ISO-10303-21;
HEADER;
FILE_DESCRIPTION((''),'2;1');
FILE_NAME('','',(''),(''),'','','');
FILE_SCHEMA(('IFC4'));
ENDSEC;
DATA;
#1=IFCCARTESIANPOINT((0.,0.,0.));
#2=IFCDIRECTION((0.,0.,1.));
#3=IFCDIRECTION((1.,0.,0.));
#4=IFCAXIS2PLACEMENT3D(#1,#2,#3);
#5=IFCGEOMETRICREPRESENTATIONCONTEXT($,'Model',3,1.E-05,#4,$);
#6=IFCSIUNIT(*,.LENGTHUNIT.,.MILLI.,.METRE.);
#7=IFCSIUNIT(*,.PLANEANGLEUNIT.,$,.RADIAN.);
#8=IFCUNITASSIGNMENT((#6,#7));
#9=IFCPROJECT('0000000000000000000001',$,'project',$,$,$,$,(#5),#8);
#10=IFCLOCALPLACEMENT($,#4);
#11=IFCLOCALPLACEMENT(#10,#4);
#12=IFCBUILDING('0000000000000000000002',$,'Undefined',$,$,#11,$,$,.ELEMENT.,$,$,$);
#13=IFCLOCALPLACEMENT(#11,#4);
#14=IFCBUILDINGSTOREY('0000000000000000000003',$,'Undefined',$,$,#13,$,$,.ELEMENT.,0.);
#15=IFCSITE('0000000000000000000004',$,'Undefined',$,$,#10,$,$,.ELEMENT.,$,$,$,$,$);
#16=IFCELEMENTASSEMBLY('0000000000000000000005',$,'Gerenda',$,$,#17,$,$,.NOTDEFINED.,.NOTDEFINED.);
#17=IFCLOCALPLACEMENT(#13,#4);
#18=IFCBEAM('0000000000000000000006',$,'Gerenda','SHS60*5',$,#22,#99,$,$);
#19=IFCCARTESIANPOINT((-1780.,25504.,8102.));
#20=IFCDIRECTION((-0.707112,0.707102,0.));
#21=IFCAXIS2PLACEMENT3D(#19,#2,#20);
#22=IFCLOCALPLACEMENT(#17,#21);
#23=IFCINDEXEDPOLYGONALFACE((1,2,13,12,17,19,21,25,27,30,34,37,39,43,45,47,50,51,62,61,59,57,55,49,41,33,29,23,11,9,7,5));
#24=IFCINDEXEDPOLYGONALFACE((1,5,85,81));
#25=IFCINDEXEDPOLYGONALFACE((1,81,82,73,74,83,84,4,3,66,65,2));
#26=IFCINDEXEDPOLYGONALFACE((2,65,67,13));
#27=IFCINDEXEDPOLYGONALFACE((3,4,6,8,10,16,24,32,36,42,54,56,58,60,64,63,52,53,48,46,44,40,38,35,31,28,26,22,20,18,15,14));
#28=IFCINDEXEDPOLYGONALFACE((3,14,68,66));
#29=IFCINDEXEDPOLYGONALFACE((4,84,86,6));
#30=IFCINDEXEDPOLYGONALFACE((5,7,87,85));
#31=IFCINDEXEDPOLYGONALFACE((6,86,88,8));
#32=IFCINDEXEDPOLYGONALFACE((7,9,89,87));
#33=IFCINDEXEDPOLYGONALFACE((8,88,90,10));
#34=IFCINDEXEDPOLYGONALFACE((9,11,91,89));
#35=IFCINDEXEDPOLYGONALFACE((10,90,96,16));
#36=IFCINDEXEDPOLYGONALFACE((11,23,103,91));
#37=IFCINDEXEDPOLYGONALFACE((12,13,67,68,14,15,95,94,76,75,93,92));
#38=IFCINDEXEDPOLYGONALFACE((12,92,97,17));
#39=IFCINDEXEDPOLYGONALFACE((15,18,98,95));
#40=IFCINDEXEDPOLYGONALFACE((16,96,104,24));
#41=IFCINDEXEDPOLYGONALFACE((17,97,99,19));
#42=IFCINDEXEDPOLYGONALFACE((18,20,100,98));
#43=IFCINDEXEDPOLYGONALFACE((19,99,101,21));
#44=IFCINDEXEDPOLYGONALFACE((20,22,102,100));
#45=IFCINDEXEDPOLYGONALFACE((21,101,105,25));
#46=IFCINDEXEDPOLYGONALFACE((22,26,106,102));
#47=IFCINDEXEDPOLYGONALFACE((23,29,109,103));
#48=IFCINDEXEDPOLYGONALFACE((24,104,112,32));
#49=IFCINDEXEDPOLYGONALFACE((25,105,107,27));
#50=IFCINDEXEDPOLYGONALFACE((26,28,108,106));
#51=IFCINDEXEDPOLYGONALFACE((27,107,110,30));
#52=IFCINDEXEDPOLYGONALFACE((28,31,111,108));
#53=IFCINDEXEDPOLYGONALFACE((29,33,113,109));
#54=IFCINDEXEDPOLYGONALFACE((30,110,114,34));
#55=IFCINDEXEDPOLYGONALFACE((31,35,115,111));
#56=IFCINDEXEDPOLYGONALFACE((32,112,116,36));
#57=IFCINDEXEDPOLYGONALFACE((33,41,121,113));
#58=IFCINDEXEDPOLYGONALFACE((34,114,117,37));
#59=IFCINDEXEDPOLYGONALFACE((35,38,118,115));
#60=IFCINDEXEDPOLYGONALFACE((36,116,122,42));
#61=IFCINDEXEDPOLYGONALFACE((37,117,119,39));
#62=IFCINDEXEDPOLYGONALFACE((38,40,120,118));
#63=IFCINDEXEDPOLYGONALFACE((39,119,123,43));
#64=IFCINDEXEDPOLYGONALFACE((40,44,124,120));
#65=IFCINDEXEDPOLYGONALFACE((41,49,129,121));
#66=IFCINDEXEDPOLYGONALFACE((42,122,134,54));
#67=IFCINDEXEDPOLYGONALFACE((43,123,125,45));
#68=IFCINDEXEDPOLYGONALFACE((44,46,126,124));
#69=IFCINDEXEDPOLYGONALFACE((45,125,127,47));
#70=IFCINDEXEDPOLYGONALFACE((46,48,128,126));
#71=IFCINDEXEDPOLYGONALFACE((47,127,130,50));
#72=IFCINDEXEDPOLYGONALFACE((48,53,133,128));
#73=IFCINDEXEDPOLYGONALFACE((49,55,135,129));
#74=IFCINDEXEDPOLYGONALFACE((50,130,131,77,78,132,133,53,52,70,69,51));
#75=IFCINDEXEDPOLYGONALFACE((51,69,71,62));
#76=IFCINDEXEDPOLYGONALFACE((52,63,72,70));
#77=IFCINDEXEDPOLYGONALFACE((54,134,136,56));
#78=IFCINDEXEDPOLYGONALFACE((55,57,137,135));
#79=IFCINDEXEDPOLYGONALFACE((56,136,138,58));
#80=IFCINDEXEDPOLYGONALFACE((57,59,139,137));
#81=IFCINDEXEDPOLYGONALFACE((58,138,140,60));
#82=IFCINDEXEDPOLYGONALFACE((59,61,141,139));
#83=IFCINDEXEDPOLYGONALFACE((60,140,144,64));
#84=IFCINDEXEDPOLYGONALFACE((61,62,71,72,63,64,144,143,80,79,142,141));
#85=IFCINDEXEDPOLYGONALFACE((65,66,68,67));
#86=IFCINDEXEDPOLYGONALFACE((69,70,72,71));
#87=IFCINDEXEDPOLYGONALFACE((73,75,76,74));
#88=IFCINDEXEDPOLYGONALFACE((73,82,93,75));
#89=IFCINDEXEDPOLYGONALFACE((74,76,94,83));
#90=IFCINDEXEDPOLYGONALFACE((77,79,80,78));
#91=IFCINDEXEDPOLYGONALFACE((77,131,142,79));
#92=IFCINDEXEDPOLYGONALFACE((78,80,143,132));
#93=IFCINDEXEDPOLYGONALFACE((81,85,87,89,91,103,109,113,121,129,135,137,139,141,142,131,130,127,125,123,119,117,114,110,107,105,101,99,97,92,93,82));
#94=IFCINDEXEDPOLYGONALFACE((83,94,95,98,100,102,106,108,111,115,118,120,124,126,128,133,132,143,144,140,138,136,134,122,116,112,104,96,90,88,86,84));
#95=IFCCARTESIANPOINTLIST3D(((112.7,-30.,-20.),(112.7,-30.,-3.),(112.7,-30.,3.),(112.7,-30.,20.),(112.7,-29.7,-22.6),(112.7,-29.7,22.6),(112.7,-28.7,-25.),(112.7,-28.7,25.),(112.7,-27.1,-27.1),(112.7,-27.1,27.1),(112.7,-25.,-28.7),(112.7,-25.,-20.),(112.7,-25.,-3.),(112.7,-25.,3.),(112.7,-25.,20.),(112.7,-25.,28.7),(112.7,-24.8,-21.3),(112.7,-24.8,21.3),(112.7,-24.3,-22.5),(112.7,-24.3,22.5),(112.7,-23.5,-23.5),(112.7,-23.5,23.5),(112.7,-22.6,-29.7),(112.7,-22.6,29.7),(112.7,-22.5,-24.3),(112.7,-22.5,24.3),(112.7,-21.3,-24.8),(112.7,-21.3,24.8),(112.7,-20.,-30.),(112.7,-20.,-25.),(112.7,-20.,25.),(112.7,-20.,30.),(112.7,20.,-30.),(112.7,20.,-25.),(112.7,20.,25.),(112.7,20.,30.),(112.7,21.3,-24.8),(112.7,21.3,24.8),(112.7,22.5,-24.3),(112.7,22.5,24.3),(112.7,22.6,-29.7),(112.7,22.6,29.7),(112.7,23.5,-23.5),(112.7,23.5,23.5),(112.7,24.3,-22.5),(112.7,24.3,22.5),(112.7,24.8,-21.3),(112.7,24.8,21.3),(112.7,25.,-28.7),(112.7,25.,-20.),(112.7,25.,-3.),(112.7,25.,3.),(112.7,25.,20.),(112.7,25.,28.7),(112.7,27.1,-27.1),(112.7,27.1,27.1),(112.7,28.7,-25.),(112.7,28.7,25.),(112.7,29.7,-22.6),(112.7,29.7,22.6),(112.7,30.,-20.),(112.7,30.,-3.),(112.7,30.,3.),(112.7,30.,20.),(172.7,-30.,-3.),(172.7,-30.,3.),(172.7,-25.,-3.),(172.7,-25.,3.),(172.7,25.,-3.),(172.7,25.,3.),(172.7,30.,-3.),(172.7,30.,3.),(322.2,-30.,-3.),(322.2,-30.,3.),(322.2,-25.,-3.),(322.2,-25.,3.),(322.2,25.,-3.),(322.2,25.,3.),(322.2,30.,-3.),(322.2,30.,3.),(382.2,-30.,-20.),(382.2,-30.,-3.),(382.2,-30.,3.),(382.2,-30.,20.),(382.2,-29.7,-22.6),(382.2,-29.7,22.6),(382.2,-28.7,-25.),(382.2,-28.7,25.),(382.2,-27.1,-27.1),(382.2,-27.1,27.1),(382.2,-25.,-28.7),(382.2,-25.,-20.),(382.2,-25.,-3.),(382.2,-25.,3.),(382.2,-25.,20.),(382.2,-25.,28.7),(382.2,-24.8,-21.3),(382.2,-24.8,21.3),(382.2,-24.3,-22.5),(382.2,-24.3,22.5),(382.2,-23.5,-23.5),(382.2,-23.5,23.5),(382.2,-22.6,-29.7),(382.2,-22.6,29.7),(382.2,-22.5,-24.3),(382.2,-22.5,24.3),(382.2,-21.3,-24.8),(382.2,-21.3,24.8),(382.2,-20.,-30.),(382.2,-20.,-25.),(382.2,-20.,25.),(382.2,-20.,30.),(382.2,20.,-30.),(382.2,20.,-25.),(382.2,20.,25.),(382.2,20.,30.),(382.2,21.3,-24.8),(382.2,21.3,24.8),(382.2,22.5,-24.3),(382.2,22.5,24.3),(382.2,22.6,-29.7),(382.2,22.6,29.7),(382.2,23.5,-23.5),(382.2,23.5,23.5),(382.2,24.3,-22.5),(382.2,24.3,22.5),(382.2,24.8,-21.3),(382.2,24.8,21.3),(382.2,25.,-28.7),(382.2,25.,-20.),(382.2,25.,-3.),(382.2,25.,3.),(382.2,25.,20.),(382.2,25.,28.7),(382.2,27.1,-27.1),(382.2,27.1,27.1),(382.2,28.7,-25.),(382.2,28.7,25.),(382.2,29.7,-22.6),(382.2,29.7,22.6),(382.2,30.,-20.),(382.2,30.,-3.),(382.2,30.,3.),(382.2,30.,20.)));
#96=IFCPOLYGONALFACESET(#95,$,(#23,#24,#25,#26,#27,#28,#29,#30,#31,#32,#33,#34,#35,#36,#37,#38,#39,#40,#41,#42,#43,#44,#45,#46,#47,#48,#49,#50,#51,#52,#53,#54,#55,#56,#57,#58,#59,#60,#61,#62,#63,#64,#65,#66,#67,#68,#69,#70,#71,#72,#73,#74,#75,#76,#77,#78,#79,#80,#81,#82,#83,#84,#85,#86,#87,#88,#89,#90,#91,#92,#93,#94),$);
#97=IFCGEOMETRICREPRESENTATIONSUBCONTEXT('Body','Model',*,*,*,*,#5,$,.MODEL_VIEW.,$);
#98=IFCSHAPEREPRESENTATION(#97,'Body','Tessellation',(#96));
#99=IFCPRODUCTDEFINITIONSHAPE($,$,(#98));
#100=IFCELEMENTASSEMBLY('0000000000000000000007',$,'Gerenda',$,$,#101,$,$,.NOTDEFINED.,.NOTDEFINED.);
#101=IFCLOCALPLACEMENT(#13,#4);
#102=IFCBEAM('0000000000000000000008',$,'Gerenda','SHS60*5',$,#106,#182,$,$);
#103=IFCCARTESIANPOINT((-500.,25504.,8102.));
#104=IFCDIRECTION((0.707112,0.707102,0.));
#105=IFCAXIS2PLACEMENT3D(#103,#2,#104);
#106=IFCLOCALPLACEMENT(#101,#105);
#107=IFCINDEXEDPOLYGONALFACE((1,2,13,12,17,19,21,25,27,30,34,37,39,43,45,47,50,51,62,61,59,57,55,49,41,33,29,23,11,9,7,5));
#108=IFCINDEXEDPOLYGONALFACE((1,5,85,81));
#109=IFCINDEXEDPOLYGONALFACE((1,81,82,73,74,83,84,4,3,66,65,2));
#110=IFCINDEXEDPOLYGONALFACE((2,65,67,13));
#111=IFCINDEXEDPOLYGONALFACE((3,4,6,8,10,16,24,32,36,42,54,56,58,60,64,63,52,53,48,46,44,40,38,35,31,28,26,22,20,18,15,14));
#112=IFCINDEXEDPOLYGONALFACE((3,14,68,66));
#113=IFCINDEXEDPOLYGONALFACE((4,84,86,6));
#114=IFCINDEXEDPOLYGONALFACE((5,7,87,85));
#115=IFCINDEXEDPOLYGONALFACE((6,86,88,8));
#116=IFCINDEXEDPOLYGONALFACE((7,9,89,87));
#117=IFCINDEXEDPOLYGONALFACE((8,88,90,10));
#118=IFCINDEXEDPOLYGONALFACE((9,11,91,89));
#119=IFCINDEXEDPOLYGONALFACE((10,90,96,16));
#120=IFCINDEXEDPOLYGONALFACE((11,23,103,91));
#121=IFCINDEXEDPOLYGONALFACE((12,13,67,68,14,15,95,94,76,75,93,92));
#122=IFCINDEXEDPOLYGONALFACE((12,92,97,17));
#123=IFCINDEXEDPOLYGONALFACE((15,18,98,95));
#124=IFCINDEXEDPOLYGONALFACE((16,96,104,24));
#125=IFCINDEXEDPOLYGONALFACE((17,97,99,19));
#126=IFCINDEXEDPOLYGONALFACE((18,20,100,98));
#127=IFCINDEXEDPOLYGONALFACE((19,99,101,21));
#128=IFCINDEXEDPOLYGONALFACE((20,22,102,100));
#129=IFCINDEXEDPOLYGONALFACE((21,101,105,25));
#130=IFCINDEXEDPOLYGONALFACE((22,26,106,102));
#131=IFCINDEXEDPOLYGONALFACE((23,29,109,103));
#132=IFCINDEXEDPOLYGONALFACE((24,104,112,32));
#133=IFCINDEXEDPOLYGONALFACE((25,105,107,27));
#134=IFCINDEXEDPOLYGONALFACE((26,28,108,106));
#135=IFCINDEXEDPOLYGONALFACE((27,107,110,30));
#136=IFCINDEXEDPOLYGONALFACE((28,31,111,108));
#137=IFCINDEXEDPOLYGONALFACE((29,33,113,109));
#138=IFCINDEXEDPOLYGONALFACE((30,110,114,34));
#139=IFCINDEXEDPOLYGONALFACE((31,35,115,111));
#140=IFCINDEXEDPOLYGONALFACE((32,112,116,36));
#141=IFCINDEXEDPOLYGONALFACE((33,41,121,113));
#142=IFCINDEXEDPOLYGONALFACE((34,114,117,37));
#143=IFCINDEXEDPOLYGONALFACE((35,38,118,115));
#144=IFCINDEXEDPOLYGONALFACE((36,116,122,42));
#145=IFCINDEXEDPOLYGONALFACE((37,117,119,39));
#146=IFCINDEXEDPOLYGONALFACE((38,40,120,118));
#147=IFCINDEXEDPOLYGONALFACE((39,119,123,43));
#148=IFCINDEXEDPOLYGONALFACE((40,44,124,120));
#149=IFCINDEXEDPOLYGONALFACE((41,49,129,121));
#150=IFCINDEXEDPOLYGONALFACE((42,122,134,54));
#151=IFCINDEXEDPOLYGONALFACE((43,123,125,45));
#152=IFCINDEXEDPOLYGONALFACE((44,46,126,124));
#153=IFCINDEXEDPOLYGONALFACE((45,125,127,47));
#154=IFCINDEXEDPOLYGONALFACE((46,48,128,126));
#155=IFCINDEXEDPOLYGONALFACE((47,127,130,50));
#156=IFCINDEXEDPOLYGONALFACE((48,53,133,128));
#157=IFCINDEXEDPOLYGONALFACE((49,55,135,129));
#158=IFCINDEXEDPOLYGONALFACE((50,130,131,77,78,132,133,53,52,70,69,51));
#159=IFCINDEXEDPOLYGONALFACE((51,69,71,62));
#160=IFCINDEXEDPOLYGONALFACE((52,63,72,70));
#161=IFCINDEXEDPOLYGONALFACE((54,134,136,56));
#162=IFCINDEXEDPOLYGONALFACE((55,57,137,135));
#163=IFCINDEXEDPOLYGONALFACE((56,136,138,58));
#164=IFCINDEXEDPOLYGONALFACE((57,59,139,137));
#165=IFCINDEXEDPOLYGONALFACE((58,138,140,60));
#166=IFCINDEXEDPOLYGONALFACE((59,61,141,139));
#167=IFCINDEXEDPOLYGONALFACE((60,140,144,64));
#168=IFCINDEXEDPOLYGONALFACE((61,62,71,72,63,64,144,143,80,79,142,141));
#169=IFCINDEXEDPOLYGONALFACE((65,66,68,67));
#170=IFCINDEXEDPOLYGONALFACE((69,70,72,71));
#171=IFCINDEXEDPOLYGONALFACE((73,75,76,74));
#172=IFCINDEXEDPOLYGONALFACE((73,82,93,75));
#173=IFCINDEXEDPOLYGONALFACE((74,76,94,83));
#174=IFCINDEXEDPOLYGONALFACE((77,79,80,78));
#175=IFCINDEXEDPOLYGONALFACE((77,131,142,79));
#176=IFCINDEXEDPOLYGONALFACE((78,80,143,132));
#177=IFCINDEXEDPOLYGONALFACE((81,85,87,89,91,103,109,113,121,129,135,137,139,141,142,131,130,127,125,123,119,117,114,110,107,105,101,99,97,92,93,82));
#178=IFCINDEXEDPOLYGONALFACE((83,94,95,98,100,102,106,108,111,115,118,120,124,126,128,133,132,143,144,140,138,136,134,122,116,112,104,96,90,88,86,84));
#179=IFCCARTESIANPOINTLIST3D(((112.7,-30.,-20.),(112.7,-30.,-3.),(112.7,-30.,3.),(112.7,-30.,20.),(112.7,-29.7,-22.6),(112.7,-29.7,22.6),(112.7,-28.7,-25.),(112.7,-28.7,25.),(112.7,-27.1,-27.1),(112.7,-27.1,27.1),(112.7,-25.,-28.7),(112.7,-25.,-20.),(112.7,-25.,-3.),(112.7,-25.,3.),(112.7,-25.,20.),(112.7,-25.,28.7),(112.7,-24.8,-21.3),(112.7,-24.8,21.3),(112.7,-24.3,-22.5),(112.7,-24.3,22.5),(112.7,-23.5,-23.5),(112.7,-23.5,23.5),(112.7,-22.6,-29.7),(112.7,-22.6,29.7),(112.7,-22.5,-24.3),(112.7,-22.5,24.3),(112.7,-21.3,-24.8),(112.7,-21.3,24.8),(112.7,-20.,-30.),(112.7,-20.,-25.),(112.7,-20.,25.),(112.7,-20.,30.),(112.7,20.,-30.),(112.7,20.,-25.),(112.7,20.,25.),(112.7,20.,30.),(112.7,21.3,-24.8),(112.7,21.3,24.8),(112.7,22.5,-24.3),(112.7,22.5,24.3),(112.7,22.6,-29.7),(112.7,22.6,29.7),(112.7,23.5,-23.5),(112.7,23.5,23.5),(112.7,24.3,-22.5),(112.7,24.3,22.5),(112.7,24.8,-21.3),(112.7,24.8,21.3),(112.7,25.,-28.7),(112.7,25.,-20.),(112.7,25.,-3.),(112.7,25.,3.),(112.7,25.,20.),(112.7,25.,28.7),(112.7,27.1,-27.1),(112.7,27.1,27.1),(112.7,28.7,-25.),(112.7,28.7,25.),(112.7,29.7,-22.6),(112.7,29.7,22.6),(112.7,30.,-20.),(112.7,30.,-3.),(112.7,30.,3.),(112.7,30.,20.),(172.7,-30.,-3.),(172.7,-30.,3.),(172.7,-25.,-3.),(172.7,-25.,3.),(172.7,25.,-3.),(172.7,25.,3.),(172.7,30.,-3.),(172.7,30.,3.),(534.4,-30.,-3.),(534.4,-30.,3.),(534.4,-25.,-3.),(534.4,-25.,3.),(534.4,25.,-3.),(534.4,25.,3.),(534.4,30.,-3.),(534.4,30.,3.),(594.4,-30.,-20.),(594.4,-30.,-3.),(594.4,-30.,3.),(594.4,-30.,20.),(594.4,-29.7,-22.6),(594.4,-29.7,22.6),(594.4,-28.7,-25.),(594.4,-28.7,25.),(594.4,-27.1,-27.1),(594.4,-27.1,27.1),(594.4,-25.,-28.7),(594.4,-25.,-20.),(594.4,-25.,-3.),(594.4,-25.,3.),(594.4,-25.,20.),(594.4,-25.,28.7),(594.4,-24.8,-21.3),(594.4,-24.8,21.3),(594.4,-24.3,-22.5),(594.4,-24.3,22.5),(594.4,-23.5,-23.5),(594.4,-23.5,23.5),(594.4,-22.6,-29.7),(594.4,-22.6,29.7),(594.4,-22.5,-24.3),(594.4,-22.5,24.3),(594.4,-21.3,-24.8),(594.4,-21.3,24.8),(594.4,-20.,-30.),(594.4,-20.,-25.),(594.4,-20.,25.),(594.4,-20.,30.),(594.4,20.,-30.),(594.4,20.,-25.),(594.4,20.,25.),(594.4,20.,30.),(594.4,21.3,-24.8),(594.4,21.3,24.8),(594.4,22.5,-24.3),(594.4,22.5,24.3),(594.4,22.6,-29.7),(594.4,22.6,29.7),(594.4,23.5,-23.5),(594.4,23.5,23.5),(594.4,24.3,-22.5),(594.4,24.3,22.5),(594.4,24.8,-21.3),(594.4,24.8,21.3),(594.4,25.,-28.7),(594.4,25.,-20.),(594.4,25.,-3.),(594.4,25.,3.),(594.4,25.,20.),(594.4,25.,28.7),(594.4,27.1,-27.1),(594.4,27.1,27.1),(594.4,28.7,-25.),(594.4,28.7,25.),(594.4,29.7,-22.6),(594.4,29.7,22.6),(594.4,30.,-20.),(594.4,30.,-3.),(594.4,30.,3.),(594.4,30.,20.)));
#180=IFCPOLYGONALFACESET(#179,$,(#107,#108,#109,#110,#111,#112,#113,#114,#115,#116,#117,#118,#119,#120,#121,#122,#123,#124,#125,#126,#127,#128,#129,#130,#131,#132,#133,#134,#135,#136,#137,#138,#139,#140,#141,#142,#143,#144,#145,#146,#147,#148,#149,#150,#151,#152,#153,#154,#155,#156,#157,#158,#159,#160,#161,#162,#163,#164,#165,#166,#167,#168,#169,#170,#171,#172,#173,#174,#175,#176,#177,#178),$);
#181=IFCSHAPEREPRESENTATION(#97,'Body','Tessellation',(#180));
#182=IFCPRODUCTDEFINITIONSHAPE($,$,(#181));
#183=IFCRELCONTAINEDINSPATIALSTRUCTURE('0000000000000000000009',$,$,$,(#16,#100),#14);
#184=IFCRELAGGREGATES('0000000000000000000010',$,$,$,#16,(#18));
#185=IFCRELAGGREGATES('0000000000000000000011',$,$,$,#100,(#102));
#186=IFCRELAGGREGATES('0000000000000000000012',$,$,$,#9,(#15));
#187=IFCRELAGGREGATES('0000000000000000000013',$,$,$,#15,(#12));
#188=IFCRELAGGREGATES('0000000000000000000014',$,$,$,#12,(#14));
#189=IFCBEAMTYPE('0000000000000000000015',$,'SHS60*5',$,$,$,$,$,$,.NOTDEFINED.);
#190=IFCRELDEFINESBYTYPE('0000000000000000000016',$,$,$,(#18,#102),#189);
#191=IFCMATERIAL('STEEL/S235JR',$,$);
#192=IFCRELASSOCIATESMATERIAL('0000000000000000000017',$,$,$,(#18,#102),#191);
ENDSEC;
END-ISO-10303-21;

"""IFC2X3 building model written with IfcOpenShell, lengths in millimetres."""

from ifc_helpers import new_model, si_unit, frame, origin_with_axes, origin_2d_with_axis, place, context, subcontext, project, spatial, rectangle, hollow_rectangle, extrude, boolean, halfspace, material, type_object, element, aggregate, save


model = new_model("IFC2X3")

# Units and contexts
model_context = context("Model", 3, precision=1e-05, world=origin_with_axes())
body_context = subcontext(model_context, "Body", "Model", "MODEL_VIEW")
ifc_project = project(units=[si_unit("LENGTHUNIT", "METRE", prefix="MILLI"), si_unit("PLANEANGLEUNIT", "RADIAN")], contexts=[model_context])

# Site, building, storey
site_placement = place(None, origin_with_axes())
site = spatial("IfcSite", under=ifc_project, at=site_placement, Name="Undefined", CompositionType="ELEMENT")
building_placement = place(site_placement, origin_with_axes())
building = spatial("IfcBuilding", under=site, at=building_placement, Name="Undefined", CompositionType="ELEMENT")
storey_placement = place(building_placement, origin_with_axes())
storey = spatial("IfcBuildingStorey", under=building, at=storey_placement, Name="Undefined", CompositionType="ELEMENT", Elevation=0.0)

# Element assemblies, beams
assembly_1_placement = place(storey_placement, origin_with_axes())
assembly_1 = element("IfcElementAssembly", 1, at=assembly_1_placement, inside=storey, Name="Gerenda", AssemblyPlace="NOTDEFINED", PredefinedType="NOTDEFINED")
ifc_material_1 = material(Name="STEEL/S235JR")
beam_type_1 = type_object("IfcBeamType", Name="SHS60*5", PredefinedType="NOTDEFINED")
beam_1_placement = place(assembly_1_placement, frame((-1780.0, 25504.0, 8102.0), z_axis=(0.0, 0.0, 1.0), x_axis=(-0.707112, 0.707102, 0.0)))
beam_1 = element("IfcBeam", 2, at=beam_1_placement, type_object=beam_type_1, material=ifc_material_1, Name="Gerenda", Description="SHS60*5", context=body_context, shape_type="CSG", body=[
    boolean("DIFFERENCE", boolean("DIFFERENCE", boolean("DIFFERENCE", boolean("DIFFERENCE", extrude(hollow_rectangle(XDim=60.0, YDim=60.0, WallThickness=5.0, InnerFilletRadius=5.0, OuterFilletRadius=10.0, at=origin_2d_with_axis()), frame((442.8, 0.0, 0.0), z_axis=(-1.0, 0.0, 0.0), x_axis=(0.0, -1.0, 0.0)), (0.0, 0.0, 1.0), 442.8), extrude(rectangle(XDim=6.0, YDim=64.0, at=origin_2d_with_axis()), frame((322.2, 0.0, 0.0), z_axis=(1.0, 0.0, 0.0), x_axis=(0.0, 0.0, -1.0)), (0.0, 0.0, 1.0), 62.0)), extrude(rectangle(XDim=6.0, YDim=64.0, at=origin_2d_with_axis()), frame((172.7, 0.0, 0.0), z_axis=(-1.0, 0.0, 0.0), x_axis=(0.0, 0.0, -1.0)), (0.0, 0.0, 1.0), 62.0)), halfspace(frame((382.2, 0.0, -9.0), z_axis=(-1.0, 0.0, 0.0), x_axis=(0.0, 1.0, 0.0)), True)), halfspace(frame((112.7, 0.0, -9.0), z_axis=(1.0, 0.0, 0.0), x_axis=(0.0, -1.0, 0.0)), True)),
])
assembly_2_placement = place(storey_placement, origin_with_axes())
assembly_2 = element("IfcElementAssembly", 3, at=assembly_2_placement, inside=storey, Name="Gerenda", AssemblyPlace="NOTDEFINED", PredefinedType="NOTDEFINED")
beam_2_placement = place(assembly_2_placement, frame((-500.0, 25504.0, 8102.0), z_axis=(0.0, 0.0, 1.0), x_axis=(0.707112, 0.707102, 0.0)))
beam_2 = element("IfcBeam", 4, at=beam_2_placement, type_object=beam_type_1, material=ifc_material_1, Name="Gerenda", Description="SHS60*5", context=body_context, shape_type="CSG", body=[
    boolean("DIFFERENCE", boolean("DIFFERENCE", boolean("DIFFERENCE", boolean("DIFFERENCE", extrude(hollow_rectangle(XDim=60.0, YDim=60.0, WallThickness=5.0, InnerFilletRadius=5.0, OuterFilletRadius=10.0, at=origin_2d_with_axis()), frame((707.1, 0.0, 0.0), z_axis=(-1.0, 0.0, 0.0), x_axis=(0.0, -1.0, 0.0)), (0.0, 0.0, 1.0), 707.1), extrude(rectangle(XDim=6.0, YDim=64.0, at=origin_2d_with_axis()), frame((172.7, 0.0, 0.0), z_axis=(-1.0, 0.0, 0.0), x_axis=(0.0, 0.0, -1.0)), (0.0, 0.0, 1.0), 62.0)), extrude(rectangle(XDim=6.0, YDim=64.0, at=origin_2d_with_axis()), frame((534.4, 0.0, 0.0), z_axis=(1.0, 0.0, 0.0), x_axis=(0.0, 0.0, -1.0)), (0.0, 0.0, 1.0), 62.0)), halfspace(frame((594.4, 0.0, -9.0), z_axis=(-1.0, 0.0, 0.0), x_axis=(0.0, 1.0, 0.0)), True)), halfspace(frame((112.7, 0.0, -9.0), z_axis=(1.0, 0.0, 0.0), x_axis=(0.0, -1.0, 0.0)), True)),
])

aggregate(assembly_1, [beam_1])
aggregate(assembly_2, [beam_2])

save(model, "model.ifc")
